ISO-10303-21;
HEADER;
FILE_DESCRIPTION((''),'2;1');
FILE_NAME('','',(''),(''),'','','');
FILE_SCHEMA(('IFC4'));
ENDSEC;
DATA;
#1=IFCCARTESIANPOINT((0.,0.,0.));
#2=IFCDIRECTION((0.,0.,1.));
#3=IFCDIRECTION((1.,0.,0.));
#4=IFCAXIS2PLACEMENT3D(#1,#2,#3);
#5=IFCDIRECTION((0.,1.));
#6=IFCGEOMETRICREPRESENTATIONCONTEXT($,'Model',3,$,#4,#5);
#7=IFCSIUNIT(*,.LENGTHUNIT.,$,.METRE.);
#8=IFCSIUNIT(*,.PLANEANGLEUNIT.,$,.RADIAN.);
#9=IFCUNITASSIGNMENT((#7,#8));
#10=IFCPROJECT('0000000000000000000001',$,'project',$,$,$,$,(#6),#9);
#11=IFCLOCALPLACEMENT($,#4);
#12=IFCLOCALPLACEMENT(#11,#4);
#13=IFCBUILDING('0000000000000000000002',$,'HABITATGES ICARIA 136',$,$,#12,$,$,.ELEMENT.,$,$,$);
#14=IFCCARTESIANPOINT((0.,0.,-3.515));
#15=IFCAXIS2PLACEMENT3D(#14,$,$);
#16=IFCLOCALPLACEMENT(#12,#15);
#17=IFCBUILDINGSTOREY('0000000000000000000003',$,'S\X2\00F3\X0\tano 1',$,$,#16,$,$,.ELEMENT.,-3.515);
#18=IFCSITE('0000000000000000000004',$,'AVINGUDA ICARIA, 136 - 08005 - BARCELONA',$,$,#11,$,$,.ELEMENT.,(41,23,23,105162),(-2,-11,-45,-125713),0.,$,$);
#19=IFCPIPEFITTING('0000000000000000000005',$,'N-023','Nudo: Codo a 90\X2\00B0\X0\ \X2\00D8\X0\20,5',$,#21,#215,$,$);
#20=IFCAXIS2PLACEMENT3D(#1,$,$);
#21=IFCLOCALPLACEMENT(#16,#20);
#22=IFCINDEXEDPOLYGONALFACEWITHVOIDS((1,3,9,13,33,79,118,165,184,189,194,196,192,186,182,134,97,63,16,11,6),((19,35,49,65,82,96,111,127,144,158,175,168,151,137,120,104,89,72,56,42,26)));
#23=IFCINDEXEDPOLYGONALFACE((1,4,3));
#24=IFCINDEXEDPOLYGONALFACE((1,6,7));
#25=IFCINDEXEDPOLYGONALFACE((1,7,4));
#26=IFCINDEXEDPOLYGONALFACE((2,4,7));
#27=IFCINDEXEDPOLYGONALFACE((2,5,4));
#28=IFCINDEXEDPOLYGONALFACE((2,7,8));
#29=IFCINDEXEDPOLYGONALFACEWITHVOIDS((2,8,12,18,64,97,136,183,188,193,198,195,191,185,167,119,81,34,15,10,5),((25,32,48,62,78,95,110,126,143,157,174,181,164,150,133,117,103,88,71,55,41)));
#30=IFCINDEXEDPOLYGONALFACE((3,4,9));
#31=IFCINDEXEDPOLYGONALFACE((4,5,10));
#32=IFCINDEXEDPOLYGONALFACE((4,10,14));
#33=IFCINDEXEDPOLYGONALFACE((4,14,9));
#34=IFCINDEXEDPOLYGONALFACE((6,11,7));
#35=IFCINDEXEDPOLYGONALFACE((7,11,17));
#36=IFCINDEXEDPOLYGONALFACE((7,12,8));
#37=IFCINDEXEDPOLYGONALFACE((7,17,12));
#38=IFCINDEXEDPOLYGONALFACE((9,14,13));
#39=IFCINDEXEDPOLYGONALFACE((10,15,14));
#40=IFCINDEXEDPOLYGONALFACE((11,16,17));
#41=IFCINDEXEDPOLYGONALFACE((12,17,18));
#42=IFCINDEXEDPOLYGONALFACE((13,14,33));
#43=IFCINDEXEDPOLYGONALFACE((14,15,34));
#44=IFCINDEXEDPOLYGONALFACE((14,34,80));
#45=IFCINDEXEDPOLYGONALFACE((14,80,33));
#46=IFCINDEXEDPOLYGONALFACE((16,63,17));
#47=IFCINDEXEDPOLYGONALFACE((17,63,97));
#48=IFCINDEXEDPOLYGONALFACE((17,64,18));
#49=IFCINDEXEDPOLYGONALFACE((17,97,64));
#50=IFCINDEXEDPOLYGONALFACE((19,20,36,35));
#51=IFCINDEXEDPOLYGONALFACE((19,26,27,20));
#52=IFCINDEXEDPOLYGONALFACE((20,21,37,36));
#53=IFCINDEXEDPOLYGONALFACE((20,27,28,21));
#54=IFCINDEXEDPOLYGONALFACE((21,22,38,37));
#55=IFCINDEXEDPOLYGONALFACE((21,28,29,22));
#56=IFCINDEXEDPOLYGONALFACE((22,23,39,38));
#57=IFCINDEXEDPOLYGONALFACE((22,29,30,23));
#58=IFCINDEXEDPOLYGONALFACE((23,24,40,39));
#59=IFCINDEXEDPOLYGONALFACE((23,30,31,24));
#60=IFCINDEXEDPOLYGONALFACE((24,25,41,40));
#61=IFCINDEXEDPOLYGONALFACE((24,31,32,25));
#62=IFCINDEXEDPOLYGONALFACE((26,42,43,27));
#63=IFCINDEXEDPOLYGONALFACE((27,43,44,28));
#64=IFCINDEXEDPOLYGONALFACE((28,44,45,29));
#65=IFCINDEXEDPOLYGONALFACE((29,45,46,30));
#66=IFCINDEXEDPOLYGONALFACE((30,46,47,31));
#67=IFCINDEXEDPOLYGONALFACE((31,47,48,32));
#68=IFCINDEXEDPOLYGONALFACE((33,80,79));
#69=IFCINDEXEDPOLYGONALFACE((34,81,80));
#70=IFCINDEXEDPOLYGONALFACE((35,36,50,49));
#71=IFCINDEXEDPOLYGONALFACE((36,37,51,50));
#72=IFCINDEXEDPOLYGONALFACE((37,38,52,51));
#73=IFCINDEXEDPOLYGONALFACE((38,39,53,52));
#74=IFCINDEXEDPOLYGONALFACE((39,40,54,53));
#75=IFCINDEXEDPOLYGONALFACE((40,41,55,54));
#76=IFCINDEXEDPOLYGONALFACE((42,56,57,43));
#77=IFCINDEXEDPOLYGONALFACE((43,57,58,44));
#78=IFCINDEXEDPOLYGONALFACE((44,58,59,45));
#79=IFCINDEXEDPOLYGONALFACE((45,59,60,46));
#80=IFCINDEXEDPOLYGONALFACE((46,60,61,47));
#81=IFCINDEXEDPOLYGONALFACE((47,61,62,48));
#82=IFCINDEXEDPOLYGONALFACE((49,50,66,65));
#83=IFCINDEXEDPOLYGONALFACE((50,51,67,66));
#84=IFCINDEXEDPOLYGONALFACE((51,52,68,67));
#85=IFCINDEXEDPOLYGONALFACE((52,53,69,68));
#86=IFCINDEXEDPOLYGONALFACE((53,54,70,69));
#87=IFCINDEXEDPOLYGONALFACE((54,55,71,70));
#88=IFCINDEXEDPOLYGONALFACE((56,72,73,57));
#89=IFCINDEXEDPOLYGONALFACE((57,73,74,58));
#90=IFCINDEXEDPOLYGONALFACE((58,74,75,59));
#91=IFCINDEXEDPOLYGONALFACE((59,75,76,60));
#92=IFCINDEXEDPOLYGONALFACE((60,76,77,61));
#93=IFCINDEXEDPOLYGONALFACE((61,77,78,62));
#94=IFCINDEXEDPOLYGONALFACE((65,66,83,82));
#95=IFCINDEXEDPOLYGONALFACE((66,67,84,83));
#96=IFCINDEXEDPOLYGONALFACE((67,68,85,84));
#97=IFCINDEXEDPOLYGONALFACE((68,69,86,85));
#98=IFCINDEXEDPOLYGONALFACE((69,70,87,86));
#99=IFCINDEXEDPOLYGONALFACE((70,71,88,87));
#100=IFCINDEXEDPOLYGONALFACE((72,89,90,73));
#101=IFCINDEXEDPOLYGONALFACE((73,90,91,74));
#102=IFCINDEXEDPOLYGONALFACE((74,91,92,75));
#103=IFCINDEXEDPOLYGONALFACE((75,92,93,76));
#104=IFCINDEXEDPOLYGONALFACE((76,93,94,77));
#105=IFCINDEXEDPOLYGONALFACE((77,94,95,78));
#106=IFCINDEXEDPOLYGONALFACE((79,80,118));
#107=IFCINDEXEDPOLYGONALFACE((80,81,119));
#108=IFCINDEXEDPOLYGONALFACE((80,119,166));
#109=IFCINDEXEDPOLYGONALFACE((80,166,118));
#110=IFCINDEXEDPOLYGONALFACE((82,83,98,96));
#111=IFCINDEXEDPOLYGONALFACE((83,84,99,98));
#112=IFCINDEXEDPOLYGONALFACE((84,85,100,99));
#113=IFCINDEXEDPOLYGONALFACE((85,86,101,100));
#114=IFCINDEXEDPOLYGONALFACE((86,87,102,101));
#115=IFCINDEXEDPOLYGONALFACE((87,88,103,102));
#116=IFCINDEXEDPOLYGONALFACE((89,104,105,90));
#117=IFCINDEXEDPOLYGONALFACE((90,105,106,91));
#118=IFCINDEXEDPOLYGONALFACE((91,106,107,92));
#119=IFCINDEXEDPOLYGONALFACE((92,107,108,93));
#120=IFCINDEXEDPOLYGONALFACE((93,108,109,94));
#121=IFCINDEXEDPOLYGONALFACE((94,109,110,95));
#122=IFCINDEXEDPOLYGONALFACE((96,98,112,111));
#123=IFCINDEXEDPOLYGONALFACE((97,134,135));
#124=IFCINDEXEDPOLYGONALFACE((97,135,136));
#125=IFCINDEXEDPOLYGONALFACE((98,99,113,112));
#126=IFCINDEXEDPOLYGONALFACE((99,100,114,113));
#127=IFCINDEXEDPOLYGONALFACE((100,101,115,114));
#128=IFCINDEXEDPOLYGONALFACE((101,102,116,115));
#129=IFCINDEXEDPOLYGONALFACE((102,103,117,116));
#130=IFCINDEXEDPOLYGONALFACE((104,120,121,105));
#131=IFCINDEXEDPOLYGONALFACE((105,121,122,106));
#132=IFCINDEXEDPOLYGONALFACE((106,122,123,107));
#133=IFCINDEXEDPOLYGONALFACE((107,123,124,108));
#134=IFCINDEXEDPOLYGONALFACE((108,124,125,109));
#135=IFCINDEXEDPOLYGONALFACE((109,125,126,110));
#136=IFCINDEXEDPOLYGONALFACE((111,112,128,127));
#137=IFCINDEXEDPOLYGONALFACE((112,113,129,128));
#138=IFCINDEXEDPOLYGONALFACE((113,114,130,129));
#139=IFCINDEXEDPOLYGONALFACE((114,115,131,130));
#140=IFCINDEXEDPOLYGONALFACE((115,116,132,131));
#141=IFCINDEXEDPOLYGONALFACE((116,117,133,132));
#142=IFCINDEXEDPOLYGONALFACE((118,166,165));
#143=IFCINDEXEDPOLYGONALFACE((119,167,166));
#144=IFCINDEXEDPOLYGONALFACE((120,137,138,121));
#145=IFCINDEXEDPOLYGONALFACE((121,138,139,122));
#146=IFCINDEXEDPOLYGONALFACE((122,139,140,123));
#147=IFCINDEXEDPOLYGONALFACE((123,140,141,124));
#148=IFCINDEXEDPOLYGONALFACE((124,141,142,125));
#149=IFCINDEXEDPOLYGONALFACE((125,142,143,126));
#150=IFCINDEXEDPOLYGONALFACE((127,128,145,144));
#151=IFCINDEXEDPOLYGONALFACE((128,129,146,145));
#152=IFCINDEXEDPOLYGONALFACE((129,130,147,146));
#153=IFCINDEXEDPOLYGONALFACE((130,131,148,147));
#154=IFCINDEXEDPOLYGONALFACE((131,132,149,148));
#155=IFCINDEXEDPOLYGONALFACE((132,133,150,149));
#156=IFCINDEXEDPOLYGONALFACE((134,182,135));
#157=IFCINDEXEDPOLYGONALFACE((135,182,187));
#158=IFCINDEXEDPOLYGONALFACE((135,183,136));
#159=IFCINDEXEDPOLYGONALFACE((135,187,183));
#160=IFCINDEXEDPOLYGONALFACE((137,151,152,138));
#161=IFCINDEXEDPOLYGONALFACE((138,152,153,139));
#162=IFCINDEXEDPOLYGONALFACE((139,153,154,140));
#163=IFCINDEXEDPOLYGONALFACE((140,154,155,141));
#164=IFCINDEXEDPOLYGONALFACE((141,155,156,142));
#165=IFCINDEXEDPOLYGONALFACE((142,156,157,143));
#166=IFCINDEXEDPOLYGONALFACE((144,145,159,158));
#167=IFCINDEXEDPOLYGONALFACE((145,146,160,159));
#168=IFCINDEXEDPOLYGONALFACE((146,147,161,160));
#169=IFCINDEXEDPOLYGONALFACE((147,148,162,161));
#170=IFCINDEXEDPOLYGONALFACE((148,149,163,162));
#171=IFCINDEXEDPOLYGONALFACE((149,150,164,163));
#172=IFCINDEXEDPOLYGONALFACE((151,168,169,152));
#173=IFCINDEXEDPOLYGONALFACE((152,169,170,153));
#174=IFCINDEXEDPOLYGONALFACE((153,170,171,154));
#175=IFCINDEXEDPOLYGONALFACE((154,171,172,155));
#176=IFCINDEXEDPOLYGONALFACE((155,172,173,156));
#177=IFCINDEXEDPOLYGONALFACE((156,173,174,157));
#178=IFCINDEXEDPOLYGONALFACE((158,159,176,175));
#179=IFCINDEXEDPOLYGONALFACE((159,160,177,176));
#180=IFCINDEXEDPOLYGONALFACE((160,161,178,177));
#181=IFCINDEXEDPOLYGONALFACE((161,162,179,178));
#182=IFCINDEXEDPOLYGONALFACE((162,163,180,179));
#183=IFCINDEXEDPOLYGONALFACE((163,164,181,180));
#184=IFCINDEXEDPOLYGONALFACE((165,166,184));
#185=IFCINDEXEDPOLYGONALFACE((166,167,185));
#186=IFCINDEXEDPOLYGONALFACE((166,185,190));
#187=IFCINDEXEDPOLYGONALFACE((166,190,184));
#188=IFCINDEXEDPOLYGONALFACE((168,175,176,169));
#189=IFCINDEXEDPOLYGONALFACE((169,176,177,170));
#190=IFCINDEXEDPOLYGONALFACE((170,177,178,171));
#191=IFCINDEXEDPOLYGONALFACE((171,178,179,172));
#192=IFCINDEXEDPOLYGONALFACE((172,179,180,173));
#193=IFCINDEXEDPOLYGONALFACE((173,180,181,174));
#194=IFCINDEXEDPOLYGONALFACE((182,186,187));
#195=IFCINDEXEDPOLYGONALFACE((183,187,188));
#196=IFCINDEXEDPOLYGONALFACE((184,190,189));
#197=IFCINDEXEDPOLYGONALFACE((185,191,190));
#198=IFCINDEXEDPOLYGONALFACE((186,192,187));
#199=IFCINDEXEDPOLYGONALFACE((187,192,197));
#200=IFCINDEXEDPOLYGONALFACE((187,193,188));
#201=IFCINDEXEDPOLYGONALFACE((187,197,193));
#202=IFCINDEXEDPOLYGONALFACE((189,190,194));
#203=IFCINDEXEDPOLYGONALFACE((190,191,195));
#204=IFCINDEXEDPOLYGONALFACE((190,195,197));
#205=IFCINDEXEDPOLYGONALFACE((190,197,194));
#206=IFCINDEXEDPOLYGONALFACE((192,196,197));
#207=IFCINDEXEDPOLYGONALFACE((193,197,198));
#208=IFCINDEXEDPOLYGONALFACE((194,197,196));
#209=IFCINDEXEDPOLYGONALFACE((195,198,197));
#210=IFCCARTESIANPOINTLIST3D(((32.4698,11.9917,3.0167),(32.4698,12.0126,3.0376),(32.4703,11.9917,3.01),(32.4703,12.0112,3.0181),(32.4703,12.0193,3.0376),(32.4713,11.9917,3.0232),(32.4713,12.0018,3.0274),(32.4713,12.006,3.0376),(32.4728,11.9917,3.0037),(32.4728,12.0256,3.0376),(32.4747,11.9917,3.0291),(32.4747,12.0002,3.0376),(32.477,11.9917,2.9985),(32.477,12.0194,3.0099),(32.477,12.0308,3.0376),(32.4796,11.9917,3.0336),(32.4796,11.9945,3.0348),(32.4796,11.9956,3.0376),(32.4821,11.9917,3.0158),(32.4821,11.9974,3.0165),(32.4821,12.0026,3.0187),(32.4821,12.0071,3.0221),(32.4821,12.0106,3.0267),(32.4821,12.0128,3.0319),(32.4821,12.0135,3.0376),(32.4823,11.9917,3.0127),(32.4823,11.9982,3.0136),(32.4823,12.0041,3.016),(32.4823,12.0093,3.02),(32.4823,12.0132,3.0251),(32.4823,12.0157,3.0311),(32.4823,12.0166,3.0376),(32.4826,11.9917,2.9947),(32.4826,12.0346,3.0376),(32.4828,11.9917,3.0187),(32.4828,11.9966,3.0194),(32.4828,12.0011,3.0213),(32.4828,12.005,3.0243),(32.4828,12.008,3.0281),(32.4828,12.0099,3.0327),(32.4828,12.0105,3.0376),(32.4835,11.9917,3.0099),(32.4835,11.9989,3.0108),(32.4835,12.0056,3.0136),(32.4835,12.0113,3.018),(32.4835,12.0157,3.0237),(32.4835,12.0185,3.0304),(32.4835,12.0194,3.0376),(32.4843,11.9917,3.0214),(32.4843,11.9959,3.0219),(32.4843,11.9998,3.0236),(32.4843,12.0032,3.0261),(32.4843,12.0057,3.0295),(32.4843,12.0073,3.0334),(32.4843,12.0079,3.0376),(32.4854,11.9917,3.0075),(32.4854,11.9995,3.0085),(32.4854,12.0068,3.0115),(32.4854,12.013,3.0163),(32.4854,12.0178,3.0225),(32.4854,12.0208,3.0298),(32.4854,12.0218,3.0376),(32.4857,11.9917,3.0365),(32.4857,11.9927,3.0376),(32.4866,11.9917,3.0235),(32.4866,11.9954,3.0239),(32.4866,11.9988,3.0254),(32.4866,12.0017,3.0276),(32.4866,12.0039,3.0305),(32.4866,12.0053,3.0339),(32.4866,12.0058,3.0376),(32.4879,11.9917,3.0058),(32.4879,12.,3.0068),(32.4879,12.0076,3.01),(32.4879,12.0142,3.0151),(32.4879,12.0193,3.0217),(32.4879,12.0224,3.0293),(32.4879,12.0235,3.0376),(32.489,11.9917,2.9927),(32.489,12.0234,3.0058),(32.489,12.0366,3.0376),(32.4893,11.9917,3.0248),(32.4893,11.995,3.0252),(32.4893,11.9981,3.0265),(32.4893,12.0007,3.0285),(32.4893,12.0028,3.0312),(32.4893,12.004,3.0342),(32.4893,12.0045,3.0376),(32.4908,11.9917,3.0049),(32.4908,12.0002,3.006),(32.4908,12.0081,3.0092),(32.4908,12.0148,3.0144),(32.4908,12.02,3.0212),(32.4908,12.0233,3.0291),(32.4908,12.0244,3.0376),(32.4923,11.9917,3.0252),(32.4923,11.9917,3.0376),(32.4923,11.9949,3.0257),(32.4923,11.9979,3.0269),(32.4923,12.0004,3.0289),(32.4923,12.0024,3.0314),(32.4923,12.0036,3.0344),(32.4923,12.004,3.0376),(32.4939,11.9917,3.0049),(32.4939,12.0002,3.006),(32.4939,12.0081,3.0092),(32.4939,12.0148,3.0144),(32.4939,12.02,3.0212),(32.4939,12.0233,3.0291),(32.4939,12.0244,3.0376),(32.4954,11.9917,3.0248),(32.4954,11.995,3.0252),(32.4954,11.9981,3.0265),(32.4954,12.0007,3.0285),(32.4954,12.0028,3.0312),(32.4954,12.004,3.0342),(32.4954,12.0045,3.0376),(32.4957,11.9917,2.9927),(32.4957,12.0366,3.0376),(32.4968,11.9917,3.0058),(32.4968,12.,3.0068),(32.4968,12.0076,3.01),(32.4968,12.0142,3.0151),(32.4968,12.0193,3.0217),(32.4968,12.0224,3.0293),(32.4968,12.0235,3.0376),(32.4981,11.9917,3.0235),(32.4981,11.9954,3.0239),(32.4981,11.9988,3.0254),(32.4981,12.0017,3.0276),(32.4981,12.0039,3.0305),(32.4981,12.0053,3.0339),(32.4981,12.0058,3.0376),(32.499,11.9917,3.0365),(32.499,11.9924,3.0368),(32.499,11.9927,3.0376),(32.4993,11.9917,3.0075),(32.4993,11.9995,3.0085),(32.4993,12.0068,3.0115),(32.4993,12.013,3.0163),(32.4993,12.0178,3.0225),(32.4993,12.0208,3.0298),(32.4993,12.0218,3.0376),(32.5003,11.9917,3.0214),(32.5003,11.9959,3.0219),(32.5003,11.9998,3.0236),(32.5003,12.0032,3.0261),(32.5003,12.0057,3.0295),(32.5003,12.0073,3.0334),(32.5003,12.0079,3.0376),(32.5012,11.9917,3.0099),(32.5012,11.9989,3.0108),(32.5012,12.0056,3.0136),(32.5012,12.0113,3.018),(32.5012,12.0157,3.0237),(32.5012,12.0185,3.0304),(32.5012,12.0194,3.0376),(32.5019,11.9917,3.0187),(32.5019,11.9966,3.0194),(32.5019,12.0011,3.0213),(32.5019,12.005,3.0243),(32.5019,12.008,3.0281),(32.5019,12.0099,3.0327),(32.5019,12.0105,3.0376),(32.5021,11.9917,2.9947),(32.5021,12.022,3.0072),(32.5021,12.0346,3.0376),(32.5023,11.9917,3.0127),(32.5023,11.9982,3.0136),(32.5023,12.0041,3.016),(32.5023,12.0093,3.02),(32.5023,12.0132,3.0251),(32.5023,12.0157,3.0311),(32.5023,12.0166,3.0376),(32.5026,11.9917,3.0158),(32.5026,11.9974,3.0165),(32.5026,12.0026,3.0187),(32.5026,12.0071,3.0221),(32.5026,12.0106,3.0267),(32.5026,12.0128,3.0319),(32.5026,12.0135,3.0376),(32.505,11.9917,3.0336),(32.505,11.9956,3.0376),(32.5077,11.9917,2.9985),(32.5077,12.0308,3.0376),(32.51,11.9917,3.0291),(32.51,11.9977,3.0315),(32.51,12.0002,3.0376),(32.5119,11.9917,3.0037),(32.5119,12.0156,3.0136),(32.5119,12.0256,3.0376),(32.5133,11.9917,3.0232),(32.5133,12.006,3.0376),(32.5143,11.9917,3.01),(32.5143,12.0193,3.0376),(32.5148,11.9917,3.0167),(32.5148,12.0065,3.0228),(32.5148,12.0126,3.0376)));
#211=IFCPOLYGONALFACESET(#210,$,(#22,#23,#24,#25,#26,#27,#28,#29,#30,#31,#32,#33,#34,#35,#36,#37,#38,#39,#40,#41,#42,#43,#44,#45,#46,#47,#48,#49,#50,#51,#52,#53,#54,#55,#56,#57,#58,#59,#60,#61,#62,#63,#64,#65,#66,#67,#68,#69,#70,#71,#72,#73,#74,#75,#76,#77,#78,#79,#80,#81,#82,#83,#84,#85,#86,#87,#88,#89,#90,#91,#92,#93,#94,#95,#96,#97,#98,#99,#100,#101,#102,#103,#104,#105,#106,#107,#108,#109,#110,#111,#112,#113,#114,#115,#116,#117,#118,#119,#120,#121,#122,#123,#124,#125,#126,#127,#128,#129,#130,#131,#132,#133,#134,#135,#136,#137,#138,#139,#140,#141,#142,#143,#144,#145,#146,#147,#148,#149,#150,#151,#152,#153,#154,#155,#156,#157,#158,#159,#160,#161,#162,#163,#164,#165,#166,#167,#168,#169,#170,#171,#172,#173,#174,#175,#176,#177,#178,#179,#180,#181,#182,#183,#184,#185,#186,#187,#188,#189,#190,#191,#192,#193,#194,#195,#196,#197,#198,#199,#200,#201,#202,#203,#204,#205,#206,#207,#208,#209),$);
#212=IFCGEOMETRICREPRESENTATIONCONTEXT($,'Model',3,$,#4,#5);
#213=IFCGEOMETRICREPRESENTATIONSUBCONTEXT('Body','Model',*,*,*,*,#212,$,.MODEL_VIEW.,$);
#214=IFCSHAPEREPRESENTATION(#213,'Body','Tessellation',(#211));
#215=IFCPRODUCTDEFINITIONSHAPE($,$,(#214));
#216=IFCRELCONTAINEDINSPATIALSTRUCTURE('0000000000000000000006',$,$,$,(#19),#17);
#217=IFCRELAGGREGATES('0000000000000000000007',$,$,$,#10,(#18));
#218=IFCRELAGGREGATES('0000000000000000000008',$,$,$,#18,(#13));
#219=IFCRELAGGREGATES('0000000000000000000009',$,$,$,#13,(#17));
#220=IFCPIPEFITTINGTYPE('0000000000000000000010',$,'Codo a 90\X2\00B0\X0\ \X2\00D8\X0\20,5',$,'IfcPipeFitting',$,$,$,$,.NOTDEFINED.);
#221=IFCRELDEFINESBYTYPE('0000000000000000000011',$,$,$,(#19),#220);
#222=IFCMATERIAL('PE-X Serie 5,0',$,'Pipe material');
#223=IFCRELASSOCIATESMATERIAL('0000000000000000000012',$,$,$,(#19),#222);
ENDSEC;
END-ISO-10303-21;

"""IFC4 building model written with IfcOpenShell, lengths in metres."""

from ifc_helpers import new_model, entity, si_unit, direction, frame, origin_with_axes, place, context, subcontext, project, spatial, source, transform, mapped, material, type_object, element, save


model = new_model("IFC4")

# Units and contexts
model_context_1 = context("Model", 3, world=origin_with_axes(), true_north=direction((0.0, 1.0)))
model_context_2 = context("Model", 3, world=origin_with_axes(), true_north=direction((0.0, 1.0)))
body_context_1 = subcontext(model_context_2, "Body", "Model", "MODEL_VIEW")
ifc_project = project(units=[si_unit("LENGTHUNIT", "METRE"), si_unit("PLANEANGLEUNIT", "RADIAN")], contexts=[model_context_1])

# Site, building, storey
site_placement = place(None, origin_with_axes())
site = spatial("IfcSite", under=ifc_project, at=site_placement, Name="AVINGUDA ICARIA, 136 - 08005 - BARCELONA", CompositionType="ELEMENT", RefLatitude=(41, 23, 23, 105162), RefLongitude=(-2, -11, -45, -125713), RefElevation=0.0)
building_placement = place(site_placement, origin_with_axes())
building = spatial("IfcBuilding", under=site, at=building_placement, Name="HABITATGES ICARIA 136", CompositionType="ELEMENT")
storey_placement = place(building_placement, frame((0.0, 0.0, -3.515)))
storey = spatial("IfcBuildingStorey", under=building, at=storey_placement, Name="Sótano 1", CompositionType="ELEMENT", Elevation=-3.515)

# Shared definitions
ifc_material_1 = material(Name="PE-X Serie 5,0", Category="Pipe material")
placement_1 = place(None, origin_with_axes())
placement_2 = place(placement_1, origin_with_axes())
placement_3 = place(placement_2, frame((0.0, 0.0, -3.515)))

# Pipe fitting
pipe_fitting_type_1 = type_object("IfcPipeFittingType", Name="Codo a 90° Ø20,5", ApplicableOccurrence="IfcPipeFitting", PredefinedType="NOTDEFINED")
shared_shape_1 = source(origin_with_axes(), body_context_1, "Body", "SweptSolid", [
    entity("IfcRevolvedAreaSolid", entity("IfcCircleHollowProfileDef", "AREA", None, entity("IfcAxis2Placement2D", entity("IfcCartesianPoint", [0.0, 0.0]), entity("IfcDirection", [1.0, 0.0])), 0.0226, 0.0123), entity("IfcAxis2Placement3D", entity("IfcCartesianPoint", [0.0226, 0.0, 0.0]), entity("IfcDirection", [-1.0, 0.0, 0.0]), entity("IfcDirection", [0.0, -1.0, 0.0])), entity("IfcAxis1Placement", entity("IfcCartesianPoint", [0.0226, 0.0, 0.0]), entity("IfcDirection", [0.0, 1.0, 0.0])), 1.570796),
])
pipe_fitting_1_placement = place(placement_3, origin_with_axes())
element("IfcPipeFitting", 1, at=pipe_fitting_1_placement, inside=storey, type_object=pipe_fitting_type_1, material=ifc_material_1, Name="N-023", Description="Nudo: Codo a 90° Ø20,5", context=body_context_1, shape_type="MappedRepresentation", body=[
    mapped(shared_shape_1, transform((32.4923, 12.0143, 3.015), x_axis=(0.0, 0.0, 1.0), y_axis=(0.0, 1.0, 0.0), z_axis=(-1.0, 0.0, 0.0), scale=1.0)),
])

save(model, "model.ifc")
